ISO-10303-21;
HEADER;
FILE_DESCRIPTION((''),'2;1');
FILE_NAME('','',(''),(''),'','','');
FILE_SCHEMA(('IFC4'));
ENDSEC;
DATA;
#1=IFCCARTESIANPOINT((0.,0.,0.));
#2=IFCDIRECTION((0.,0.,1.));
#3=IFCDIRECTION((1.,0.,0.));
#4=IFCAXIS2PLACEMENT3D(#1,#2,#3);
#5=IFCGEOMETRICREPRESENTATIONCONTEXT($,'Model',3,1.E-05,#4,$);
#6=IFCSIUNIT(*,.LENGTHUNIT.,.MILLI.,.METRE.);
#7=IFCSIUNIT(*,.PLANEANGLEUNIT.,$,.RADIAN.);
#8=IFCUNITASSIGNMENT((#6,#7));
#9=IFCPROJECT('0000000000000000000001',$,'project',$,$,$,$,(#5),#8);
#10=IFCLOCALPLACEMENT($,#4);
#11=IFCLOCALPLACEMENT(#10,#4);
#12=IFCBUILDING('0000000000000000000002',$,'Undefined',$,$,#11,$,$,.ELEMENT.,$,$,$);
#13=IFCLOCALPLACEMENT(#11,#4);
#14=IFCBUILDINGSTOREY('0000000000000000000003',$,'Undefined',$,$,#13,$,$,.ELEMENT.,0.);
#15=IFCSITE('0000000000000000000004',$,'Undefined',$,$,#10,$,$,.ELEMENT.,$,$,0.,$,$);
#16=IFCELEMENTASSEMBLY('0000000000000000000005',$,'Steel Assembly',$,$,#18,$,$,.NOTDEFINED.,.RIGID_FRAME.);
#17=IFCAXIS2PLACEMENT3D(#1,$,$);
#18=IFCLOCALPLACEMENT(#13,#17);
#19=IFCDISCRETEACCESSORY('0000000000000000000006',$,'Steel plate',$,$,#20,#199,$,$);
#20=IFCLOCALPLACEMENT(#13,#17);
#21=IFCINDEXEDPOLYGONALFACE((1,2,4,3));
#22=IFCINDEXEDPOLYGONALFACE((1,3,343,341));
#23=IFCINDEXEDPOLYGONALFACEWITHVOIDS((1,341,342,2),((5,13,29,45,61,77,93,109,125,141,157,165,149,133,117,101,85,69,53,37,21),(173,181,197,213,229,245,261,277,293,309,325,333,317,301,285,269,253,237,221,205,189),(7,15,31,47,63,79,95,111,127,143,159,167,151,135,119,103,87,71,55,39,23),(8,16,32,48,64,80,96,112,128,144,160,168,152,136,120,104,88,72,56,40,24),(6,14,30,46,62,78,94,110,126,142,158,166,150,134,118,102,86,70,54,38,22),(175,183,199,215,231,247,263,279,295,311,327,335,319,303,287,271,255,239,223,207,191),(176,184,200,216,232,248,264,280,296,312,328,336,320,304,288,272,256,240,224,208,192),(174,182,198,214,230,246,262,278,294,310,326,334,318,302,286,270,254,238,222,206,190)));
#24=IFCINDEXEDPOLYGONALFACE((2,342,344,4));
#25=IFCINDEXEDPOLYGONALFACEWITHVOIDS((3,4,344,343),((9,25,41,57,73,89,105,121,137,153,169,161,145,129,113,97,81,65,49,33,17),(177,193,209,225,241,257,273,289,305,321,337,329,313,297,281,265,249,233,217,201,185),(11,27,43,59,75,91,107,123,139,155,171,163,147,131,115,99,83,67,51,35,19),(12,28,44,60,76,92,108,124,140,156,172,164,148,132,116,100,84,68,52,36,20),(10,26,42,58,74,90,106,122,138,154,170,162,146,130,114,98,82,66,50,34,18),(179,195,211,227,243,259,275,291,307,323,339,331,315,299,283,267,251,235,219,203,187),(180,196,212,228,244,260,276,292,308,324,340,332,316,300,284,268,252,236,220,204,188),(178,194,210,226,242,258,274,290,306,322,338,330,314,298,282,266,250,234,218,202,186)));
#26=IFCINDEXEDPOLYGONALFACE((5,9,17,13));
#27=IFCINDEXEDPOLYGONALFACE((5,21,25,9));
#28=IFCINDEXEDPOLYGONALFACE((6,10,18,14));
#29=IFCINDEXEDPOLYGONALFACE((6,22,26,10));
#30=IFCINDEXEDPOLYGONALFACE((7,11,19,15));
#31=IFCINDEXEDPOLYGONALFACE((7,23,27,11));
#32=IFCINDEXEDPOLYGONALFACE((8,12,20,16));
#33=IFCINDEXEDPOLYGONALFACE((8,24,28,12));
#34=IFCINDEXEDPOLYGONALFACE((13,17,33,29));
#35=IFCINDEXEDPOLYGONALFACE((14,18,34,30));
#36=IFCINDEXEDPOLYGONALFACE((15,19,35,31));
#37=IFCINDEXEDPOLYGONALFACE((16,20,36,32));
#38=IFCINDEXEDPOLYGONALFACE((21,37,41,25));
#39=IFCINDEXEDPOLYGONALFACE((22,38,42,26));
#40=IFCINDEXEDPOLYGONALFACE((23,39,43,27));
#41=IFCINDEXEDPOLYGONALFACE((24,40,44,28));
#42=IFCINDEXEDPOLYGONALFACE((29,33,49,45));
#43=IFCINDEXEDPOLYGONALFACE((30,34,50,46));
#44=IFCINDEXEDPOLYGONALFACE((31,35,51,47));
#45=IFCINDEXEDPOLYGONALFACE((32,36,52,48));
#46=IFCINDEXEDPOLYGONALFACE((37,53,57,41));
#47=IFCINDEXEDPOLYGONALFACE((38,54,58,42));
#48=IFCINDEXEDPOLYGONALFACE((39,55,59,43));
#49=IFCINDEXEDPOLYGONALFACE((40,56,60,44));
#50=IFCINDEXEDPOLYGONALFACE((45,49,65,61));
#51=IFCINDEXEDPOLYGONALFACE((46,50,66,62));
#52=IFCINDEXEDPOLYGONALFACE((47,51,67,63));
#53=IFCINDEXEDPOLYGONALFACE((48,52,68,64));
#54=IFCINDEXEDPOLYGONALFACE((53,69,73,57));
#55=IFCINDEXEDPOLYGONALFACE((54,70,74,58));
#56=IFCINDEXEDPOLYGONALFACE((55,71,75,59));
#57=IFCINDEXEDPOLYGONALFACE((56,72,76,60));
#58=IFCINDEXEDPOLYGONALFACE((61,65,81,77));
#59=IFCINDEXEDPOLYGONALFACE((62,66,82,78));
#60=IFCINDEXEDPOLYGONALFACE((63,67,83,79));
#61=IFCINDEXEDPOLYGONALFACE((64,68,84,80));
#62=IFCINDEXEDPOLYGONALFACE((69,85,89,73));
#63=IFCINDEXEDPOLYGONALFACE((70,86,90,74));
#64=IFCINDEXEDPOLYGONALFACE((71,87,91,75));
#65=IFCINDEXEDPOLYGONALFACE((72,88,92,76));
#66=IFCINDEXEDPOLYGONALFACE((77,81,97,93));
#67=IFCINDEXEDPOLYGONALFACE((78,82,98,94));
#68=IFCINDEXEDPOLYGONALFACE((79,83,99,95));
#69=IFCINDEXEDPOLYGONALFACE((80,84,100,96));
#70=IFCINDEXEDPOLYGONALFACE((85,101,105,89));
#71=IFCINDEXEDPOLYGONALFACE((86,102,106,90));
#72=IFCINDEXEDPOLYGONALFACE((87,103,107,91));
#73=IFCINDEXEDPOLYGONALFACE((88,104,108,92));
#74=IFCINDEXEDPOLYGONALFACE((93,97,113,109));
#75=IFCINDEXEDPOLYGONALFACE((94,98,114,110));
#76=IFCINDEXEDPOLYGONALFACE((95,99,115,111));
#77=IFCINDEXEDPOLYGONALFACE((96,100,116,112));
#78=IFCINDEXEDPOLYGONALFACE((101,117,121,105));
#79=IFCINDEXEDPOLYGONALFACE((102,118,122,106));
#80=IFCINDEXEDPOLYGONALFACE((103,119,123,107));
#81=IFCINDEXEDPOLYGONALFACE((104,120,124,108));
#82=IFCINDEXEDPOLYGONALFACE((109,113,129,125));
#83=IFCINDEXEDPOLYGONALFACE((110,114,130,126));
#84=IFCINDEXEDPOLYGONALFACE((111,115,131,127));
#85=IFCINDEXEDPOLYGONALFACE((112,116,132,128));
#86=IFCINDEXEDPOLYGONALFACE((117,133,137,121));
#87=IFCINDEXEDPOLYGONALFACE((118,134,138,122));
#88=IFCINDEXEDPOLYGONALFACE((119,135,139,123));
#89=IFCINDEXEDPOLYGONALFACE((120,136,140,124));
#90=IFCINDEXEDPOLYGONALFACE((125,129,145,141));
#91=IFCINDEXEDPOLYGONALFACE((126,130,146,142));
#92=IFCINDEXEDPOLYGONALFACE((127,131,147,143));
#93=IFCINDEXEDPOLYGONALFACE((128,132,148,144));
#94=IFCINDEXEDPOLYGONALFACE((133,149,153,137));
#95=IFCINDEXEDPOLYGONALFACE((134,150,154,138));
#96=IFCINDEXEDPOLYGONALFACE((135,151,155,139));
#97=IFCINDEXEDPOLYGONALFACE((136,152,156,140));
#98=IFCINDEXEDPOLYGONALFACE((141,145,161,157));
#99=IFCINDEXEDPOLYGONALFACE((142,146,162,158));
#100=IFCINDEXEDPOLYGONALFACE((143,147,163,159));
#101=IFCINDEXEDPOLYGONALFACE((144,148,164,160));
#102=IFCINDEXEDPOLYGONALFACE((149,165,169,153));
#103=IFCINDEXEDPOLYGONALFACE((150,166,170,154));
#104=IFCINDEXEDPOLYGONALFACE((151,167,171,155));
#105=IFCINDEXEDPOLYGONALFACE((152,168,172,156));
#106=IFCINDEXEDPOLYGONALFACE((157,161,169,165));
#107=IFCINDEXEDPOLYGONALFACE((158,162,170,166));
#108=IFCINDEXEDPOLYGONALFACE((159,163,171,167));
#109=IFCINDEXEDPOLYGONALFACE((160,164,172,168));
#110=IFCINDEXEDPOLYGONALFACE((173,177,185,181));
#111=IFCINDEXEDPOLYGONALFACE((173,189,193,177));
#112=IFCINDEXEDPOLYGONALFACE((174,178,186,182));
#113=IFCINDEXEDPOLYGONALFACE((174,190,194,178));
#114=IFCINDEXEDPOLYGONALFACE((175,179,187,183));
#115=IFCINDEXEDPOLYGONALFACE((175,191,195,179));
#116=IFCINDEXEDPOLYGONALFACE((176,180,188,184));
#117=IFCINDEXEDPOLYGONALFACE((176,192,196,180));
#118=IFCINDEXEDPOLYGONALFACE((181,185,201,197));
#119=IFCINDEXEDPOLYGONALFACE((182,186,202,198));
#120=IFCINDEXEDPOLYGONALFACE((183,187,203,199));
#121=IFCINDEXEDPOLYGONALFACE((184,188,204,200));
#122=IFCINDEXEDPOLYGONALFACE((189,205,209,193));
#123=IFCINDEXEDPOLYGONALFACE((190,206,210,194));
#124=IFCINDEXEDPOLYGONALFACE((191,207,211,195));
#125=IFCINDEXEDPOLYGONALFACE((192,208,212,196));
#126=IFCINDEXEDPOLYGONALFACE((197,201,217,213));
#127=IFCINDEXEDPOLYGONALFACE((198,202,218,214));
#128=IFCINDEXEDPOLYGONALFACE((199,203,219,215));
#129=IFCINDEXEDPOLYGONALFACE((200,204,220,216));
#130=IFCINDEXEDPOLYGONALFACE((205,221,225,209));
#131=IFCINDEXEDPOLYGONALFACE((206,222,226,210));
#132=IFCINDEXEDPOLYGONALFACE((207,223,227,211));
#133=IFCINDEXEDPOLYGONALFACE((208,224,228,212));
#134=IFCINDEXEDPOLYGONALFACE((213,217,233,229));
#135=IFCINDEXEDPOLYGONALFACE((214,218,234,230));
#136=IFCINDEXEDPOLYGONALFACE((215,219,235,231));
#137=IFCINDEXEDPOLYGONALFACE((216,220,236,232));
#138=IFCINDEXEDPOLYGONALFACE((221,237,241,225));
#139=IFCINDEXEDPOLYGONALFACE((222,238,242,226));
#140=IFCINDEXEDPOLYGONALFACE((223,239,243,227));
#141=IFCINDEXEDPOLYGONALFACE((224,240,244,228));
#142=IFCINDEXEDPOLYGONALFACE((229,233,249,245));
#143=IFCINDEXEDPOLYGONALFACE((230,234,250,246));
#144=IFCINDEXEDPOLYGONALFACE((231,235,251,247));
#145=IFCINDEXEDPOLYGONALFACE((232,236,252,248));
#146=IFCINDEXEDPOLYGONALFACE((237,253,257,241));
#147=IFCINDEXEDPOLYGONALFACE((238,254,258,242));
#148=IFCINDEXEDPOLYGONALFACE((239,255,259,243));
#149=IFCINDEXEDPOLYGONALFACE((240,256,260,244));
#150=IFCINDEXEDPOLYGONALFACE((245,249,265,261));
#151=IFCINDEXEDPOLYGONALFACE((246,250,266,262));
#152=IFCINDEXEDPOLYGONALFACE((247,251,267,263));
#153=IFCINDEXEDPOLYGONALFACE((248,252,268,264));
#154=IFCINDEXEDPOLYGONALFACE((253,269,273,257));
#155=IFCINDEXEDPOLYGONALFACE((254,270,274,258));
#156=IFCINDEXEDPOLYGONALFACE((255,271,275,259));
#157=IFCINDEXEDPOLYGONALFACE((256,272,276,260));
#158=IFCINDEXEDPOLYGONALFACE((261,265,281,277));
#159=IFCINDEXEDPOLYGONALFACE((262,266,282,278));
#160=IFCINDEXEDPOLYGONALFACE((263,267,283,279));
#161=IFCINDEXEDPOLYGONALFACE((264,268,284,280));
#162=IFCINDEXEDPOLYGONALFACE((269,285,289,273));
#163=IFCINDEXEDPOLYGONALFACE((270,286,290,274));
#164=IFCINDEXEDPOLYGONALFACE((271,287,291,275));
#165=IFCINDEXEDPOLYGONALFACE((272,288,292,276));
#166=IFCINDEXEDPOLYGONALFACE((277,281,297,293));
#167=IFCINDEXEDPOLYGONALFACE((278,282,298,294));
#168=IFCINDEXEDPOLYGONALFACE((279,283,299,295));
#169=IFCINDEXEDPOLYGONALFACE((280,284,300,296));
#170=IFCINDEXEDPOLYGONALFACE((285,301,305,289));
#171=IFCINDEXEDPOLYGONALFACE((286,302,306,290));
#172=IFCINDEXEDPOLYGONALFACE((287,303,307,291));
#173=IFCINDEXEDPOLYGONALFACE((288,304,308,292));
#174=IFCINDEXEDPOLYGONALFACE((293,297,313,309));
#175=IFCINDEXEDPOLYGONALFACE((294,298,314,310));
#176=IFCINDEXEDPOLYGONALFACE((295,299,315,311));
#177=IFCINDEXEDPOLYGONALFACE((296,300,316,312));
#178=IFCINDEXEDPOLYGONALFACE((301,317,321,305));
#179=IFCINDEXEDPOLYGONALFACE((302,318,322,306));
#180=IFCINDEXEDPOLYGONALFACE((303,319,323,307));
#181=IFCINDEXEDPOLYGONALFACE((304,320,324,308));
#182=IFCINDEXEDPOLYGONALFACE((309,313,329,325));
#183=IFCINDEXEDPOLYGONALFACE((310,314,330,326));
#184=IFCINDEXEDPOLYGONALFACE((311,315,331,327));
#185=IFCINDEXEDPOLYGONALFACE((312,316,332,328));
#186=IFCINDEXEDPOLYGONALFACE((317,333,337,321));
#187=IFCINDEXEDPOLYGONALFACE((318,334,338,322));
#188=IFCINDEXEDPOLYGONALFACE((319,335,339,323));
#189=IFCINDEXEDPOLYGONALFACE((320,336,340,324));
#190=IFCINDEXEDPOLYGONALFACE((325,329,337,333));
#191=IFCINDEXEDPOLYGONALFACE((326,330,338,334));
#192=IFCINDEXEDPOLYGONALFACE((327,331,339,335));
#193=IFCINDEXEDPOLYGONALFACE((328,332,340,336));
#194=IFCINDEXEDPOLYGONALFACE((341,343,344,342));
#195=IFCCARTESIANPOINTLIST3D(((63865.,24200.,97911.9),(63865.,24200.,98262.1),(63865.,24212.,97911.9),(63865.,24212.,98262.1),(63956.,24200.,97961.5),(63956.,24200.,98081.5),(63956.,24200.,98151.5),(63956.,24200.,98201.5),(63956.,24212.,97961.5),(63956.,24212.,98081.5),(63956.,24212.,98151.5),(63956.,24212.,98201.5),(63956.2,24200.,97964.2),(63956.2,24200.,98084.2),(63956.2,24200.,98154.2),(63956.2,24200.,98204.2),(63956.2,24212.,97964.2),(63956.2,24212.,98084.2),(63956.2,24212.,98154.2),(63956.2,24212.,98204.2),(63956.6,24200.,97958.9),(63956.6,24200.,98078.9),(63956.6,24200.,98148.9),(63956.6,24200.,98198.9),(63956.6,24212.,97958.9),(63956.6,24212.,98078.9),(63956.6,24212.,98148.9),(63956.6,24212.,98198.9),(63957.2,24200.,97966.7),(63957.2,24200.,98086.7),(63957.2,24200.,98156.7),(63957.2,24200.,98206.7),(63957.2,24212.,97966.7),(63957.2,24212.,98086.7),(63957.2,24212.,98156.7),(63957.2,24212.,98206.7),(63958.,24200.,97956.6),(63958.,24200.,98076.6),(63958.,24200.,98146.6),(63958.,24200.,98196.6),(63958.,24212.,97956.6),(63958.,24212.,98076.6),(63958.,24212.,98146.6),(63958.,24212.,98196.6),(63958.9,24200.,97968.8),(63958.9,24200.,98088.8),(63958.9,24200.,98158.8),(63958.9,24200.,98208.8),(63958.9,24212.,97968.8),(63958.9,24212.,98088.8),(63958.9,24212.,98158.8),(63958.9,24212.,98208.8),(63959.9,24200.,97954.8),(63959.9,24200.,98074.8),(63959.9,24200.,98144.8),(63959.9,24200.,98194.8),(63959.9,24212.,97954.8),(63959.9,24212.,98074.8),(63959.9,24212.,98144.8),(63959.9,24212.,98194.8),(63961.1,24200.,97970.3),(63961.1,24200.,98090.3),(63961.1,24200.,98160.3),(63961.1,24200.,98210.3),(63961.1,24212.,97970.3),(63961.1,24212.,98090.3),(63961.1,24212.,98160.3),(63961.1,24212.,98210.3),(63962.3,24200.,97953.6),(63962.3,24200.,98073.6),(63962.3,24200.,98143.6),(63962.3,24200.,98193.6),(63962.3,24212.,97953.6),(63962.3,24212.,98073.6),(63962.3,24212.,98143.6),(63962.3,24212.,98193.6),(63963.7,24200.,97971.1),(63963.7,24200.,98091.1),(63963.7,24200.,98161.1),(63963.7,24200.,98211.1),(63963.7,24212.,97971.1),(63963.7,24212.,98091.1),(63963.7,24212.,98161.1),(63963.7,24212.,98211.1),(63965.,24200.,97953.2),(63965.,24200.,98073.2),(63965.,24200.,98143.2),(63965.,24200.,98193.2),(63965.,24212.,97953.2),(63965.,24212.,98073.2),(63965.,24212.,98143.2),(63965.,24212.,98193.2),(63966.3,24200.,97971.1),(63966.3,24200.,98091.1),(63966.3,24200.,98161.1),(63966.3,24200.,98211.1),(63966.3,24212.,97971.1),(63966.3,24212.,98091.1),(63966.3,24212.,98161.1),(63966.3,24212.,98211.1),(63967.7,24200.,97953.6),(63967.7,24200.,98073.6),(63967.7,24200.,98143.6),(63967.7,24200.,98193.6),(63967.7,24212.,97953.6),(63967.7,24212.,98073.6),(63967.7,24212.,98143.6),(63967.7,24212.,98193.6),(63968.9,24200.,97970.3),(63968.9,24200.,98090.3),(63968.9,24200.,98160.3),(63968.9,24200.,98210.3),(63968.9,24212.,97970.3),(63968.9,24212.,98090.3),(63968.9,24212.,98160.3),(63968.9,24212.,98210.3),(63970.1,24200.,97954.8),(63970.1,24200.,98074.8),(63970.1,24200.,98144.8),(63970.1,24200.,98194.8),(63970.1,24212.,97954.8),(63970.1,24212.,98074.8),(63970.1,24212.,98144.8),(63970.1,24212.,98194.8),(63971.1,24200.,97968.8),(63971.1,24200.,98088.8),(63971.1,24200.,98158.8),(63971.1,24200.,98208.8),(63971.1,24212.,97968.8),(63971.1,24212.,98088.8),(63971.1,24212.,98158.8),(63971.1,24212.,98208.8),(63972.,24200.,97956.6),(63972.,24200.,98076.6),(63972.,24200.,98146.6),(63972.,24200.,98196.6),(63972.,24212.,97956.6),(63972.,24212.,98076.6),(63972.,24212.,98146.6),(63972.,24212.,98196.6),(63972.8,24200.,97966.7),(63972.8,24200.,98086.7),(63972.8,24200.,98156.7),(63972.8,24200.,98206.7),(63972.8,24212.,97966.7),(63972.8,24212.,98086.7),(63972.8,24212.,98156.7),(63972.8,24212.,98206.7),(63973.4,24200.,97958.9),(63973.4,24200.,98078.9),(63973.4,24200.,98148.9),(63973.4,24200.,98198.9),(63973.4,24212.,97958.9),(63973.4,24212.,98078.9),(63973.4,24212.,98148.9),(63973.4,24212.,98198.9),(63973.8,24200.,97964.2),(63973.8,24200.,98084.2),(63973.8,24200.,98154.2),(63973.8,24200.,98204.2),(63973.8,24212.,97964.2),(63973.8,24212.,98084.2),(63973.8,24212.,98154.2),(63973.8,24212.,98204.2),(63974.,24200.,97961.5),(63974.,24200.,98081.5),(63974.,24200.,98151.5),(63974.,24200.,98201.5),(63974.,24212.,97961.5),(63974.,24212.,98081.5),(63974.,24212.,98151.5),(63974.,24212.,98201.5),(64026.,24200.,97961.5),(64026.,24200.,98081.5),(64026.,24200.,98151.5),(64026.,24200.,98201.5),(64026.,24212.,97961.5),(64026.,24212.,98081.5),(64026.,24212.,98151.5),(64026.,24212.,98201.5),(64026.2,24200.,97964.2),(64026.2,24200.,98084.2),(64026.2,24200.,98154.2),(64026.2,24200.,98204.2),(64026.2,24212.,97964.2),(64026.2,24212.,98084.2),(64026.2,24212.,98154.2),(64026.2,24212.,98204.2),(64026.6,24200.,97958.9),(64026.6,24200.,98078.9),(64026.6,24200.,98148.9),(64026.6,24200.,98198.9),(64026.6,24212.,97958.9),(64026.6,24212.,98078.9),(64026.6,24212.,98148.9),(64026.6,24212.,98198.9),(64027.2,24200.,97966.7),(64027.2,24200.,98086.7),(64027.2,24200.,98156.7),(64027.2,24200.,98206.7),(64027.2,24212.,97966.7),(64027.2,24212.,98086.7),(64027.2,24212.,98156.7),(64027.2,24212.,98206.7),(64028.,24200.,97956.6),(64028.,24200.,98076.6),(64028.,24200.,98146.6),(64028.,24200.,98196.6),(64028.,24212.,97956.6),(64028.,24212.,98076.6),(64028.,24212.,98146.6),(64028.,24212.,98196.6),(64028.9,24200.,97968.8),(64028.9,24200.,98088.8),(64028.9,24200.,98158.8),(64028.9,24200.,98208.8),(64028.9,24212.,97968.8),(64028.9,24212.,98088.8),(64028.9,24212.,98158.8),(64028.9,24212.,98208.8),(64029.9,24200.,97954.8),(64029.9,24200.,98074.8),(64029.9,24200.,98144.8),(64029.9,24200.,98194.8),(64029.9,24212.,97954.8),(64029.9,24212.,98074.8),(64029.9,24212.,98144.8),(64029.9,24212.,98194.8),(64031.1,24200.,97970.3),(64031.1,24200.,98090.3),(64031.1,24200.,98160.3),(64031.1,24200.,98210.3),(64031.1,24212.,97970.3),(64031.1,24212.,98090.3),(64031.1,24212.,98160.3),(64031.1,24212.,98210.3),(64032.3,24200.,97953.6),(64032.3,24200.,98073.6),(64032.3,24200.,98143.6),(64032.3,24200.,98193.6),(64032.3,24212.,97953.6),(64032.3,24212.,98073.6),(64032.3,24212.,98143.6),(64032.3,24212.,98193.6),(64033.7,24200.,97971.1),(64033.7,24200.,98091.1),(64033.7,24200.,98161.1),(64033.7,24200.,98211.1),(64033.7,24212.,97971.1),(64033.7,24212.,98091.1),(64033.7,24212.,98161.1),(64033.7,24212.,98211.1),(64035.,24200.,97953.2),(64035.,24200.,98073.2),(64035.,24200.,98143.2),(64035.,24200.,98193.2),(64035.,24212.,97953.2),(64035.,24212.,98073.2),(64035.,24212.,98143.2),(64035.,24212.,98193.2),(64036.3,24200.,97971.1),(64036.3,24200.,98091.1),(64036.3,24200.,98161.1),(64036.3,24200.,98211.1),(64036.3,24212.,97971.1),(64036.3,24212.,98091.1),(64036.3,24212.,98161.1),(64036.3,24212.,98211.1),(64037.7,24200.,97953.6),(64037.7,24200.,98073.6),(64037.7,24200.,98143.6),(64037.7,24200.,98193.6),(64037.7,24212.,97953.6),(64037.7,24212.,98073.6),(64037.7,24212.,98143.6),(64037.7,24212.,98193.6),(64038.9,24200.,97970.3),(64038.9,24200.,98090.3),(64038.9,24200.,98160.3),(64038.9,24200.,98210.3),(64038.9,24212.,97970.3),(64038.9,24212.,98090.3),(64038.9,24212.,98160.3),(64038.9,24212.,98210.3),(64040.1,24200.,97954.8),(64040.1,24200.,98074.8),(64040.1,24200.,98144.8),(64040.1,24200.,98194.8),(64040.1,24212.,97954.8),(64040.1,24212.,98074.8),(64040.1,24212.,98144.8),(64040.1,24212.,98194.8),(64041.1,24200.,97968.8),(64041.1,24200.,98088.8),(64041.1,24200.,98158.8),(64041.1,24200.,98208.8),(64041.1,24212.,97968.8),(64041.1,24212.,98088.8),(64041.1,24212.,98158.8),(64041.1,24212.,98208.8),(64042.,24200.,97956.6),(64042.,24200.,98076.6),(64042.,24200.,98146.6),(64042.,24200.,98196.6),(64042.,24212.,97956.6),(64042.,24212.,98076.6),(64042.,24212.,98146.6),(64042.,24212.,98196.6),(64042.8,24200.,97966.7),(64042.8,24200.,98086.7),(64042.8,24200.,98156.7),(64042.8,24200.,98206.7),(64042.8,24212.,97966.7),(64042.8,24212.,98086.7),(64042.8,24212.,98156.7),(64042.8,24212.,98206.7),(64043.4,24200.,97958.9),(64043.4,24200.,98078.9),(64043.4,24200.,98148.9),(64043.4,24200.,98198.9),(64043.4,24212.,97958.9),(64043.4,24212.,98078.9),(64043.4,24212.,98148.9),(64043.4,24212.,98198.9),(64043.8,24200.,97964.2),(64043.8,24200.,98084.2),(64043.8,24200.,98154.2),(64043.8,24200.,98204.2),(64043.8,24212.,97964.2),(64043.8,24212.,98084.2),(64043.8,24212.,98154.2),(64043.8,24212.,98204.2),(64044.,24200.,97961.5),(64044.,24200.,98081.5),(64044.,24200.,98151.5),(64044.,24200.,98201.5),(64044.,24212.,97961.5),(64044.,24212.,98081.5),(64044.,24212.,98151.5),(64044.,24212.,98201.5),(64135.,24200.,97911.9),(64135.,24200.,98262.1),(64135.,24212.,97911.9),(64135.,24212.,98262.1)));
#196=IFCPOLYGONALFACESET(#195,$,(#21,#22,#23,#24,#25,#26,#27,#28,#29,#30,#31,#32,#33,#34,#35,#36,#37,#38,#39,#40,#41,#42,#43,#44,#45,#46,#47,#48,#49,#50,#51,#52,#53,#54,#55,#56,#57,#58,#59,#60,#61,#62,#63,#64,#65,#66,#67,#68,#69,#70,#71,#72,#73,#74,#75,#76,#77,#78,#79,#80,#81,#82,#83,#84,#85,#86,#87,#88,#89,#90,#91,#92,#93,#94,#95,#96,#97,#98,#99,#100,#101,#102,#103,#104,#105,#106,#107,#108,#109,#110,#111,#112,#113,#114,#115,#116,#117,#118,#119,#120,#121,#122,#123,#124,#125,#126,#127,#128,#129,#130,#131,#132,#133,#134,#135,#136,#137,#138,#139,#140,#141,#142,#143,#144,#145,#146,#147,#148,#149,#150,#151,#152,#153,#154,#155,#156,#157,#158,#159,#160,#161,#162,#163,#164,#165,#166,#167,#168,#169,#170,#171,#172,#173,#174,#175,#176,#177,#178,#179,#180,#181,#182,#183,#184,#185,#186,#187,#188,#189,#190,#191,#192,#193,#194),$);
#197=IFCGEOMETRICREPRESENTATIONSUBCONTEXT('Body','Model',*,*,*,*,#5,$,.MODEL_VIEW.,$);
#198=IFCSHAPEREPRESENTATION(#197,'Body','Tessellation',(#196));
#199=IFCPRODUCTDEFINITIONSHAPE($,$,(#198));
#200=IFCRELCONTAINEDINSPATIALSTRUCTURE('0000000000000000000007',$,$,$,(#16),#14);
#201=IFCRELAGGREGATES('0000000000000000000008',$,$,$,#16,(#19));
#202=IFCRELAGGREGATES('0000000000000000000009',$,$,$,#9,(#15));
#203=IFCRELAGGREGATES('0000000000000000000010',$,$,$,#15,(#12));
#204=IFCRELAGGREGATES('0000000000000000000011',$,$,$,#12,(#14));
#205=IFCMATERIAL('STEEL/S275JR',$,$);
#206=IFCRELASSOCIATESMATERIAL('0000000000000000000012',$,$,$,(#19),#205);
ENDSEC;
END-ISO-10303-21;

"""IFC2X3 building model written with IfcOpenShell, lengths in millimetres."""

from ifc_helpers import new_model, si_unit, frame, origin_with_axes, origin_2d_with_axis, place, context, subcontext, project, spatial, polyline, circle, outline, extrude, source, transform, mapped, material, element, aggregate, save


model = new_model("IFC2X3")

# Units and contexts
model_context = context("Model", 3, precision=1e-05, world=origin_with_axes())
body_context = subcontext(model_context, "Body", "Model", "MODEL_VIEW")
ifc_project = project(units=[si_unit("LENGTHUNIT", "METRE", prefix="MILLI"), si_unit("PLANEANGLEUNIT", "RADIAN")], contexts=[model_context])

# Site, building, storey
site_placement = place(None, origin_with_axes())
site = spatial("IfcSite", under=ifc_project, at=site_placement, Name="Undefined", CompositionType="ELEMENT", RefElevation=0.0)
building_placement = place(site_placement, origin_with_axes())
building = spatial("IfcBuilding", under=site, at=building_placement, Name="Undefined", CompositionType="ELEMENT")
storey_placement = place(building_placement, origin_with_axes())
storey = spatial("IfcBuildingStorey", under=building, at=storey_placement, Name="Undefined", CompositionType="ELEMENT", Elevation=0.0)

# Shared definitions
ifc_material_1 = material(Name="STEEL/S275JR")

# Element assembly, discrete accessory, opening
assembly_1_placement = place(storey_placement, origin_with_axes())
assembly_1 = element("IfcElementAssembly", 1, at=assembly_1_placement, inside=storey, Name="Steel Assembly", AssemblyPlace="NOTDEFINED", PredefinedType="RIGID_FRAME")
discrete_accessory_1_placement = place(assembly_1_placement, frame((63865.0, 24206.0, 97911.9), z_axis=(0.0, -1.0, 0.0), x_axis=(1.0, 0.0, 0.0)))
discrete_accessory_1 = element("IfcDiscreteAccessory", 2, at=discrete_accessory_1_placement, material=ifc_material_1, Name="Steel plate", context=body_context, shape_type="SweptSolid", body=[
    extrude(outline(polyline([(0.0, 0.0), (270.0, 0.0), (270.0, 350.2), (0.0, 350.2), (0.0, 0.0)])), frame((0.0, 0.0, -6.0), z_axis=(0.0, 0.0, 1.0), x_axis=(1.0, 0.0, 0.0)), (0.0, 0.0, 1.0), 12.0),
])
shared_shape_1 = source(origin_with_axes(), body_context, "Body", "SweptSolid", [
    extrude(circle(Radius=9.0, at=origin_2d_with_axis()), frame((0.0, 17.9, 0.0), z_axis=(0.0, 1.0, 0.0), x_axis=(1.0, 0.0, 0.0)), (0.0, 0.0, 1.0), 30.1),
])
opening_1_placement = place(assembly_1_placement, frame((64000.0, 24182.0, 98202.2), z_axis=(1.0, 0.0, 0.0), x_axis=(0.0, 0.0, -1.0)))
element("IfcOpeningElement", 3, at=opening_1_placement, cuts=discrete_accessory_1, ObjectType="Opening", context=body_context, shape_type="MappedRepresentation", body=[
    mapped(shared_shape_1, transform((0.0, 0.0, -35.0))),
    mapped(shared_shape_1, transform((50.0, 0.0, -35.0))),
    mapped(shared_shape_1, transform((120.0, 0.0, -35.0))),
    mapped(shared_shape_1, transform((240.0, 0.0, -35.0))),
    mapped(shared_shape_1, transform((0.0, 0.0, 35.0))),
    mapped(shared_shape_1, transform((50.0, 0.0, 35.0))),
    mapped(shared_shape_1, transform((120.0, 0.0, 35.0))),
    mapped(shared_shape_1, transform((240.0, 0.0, 35.0))),
])
aggregate(assembly_1, [discrete_accessory_1])

save(model, "model.ifc")
